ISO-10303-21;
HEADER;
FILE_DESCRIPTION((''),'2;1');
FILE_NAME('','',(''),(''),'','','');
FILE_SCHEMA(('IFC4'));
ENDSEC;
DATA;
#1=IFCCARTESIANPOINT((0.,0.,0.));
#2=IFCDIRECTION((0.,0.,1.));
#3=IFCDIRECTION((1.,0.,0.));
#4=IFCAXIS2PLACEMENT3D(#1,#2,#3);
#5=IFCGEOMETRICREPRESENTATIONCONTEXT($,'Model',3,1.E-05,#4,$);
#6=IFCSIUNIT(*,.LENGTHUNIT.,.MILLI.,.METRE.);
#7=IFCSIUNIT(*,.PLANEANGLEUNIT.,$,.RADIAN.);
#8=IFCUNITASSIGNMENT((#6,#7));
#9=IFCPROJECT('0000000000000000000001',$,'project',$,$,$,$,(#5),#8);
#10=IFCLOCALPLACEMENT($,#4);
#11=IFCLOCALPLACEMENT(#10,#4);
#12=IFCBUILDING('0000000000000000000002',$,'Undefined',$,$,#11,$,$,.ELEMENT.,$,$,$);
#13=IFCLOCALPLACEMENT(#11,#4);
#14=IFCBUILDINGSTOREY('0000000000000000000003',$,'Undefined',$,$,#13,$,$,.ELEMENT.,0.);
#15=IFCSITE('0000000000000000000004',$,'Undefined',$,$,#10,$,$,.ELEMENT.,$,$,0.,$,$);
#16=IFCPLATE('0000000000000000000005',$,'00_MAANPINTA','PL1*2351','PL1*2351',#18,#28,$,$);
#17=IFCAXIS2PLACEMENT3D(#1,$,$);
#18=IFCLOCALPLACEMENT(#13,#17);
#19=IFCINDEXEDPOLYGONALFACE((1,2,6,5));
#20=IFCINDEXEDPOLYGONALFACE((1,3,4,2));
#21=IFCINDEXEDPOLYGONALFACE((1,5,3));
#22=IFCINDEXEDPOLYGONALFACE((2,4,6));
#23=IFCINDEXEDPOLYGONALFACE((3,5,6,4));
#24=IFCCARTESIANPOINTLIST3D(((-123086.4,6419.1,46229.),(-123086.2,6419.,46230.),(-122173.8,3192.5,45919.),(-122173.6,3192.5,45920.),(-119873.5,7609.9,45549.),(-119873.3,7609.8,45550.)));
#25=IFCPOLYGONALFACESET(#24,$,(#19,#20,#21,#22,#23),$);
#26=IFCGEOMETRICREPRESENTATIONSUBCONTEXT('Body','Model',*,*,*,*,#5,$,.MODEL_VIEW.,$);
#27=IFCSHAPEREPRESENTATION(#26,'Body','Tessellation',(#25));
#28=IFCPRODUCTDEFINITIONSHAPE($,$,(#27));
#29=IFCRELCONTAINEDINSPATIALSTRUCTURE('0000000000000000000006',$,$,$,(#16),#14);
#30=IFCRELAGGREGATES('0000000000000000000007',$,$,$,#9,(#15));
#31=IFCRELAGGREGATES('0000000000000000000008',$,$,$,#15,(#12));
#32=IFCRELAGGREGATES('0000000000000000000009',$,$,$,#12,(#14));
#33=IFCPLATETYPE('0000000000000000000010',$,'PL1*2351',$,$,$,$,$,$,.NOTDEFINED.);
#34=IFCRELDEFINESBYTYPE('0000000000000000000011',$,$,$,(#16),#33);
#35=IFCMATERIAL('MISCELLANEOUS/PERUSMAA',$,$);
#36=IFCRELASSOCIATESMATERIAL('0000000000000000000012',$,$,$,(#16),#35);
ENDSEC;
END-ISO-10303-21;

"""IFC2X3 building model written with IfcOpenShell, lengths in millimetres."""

from ifc_helpers import new_model, si_unit, frame, origin_with_axes, place, context, subcontext, project, spatial, polyline, outline, extrude, material, type_object, element, save


model = new_model("IFC2X3")

# Units and contexts
model_context = context("Model", 3, precision=1e-05, world=origin_with_axes())
body_context = subcontext(model_context, "Body", "Model", "MODEL_VIEW")
ifc_project = project(units=[si_unit("LENGTHUNIT", "METRE", prefix="MILLI"), si_unit("PLANEANGLEUNIT", "RADIAN")], contexts=[model_context])

# Site, building, storey
site_placement = place(None, origin_with_axes())
site = spatial("IfcSite", under=ifc_project, at=site_placement, Name="Undefined", CompositionType="ELEMENT", RefElevation=0.0)
building_placement = place(site_placement, origin_with_axes())
building = spatial("IfcBuilding", under=site, at=building_placement, Name="Undefined", CompositionType="ELEMENT")
storey_placement = place(building_placement, origin_with_axes())
storey = spatial("IfcBuildingStorey", under=building, at=storey_placement, Name="Undefined", CompositionType="ELEMENT", Elevation=0.0)

# Plate
ifc_material = material(Name="MISCELLANEOUS/PERUSMAA")
plate_type_1 = type_object("IfcPlateType", Name="PL1*2351", PredefinedType="NOTDEFINED")
plate_1_placement = place(storey_placement, frame((-122173.7, 3192.5, 45919.5), z_axis=(-0.218285, 0.031974, -0.975361), x_axis=(-0.270997, 0.958168, 0.092059)))
element("IfcPlate", 1, at=plate_1_placement, inside=storey, type_object=plate_type_1, material=ifc_material, Name="00_MAANPINTA", Description="PL1*2351", ObjectType="PL1*2351", context=body_context, shape_type="SweptSolid", body=[
    extrude(outline(polyline([(0.0, 0.0), (3367.4, 0.0), (3575.1, 3487.1), (0.0, 0.0)])), frame((0.0, 0.0, -0.5), z_axis=(0.0, 0.0, 1.0), x_axis=(1.0, 0.0, 0.0)), (0.0, 0.0, 1.0), 1.0),
])

save(model, "model.ifc")
